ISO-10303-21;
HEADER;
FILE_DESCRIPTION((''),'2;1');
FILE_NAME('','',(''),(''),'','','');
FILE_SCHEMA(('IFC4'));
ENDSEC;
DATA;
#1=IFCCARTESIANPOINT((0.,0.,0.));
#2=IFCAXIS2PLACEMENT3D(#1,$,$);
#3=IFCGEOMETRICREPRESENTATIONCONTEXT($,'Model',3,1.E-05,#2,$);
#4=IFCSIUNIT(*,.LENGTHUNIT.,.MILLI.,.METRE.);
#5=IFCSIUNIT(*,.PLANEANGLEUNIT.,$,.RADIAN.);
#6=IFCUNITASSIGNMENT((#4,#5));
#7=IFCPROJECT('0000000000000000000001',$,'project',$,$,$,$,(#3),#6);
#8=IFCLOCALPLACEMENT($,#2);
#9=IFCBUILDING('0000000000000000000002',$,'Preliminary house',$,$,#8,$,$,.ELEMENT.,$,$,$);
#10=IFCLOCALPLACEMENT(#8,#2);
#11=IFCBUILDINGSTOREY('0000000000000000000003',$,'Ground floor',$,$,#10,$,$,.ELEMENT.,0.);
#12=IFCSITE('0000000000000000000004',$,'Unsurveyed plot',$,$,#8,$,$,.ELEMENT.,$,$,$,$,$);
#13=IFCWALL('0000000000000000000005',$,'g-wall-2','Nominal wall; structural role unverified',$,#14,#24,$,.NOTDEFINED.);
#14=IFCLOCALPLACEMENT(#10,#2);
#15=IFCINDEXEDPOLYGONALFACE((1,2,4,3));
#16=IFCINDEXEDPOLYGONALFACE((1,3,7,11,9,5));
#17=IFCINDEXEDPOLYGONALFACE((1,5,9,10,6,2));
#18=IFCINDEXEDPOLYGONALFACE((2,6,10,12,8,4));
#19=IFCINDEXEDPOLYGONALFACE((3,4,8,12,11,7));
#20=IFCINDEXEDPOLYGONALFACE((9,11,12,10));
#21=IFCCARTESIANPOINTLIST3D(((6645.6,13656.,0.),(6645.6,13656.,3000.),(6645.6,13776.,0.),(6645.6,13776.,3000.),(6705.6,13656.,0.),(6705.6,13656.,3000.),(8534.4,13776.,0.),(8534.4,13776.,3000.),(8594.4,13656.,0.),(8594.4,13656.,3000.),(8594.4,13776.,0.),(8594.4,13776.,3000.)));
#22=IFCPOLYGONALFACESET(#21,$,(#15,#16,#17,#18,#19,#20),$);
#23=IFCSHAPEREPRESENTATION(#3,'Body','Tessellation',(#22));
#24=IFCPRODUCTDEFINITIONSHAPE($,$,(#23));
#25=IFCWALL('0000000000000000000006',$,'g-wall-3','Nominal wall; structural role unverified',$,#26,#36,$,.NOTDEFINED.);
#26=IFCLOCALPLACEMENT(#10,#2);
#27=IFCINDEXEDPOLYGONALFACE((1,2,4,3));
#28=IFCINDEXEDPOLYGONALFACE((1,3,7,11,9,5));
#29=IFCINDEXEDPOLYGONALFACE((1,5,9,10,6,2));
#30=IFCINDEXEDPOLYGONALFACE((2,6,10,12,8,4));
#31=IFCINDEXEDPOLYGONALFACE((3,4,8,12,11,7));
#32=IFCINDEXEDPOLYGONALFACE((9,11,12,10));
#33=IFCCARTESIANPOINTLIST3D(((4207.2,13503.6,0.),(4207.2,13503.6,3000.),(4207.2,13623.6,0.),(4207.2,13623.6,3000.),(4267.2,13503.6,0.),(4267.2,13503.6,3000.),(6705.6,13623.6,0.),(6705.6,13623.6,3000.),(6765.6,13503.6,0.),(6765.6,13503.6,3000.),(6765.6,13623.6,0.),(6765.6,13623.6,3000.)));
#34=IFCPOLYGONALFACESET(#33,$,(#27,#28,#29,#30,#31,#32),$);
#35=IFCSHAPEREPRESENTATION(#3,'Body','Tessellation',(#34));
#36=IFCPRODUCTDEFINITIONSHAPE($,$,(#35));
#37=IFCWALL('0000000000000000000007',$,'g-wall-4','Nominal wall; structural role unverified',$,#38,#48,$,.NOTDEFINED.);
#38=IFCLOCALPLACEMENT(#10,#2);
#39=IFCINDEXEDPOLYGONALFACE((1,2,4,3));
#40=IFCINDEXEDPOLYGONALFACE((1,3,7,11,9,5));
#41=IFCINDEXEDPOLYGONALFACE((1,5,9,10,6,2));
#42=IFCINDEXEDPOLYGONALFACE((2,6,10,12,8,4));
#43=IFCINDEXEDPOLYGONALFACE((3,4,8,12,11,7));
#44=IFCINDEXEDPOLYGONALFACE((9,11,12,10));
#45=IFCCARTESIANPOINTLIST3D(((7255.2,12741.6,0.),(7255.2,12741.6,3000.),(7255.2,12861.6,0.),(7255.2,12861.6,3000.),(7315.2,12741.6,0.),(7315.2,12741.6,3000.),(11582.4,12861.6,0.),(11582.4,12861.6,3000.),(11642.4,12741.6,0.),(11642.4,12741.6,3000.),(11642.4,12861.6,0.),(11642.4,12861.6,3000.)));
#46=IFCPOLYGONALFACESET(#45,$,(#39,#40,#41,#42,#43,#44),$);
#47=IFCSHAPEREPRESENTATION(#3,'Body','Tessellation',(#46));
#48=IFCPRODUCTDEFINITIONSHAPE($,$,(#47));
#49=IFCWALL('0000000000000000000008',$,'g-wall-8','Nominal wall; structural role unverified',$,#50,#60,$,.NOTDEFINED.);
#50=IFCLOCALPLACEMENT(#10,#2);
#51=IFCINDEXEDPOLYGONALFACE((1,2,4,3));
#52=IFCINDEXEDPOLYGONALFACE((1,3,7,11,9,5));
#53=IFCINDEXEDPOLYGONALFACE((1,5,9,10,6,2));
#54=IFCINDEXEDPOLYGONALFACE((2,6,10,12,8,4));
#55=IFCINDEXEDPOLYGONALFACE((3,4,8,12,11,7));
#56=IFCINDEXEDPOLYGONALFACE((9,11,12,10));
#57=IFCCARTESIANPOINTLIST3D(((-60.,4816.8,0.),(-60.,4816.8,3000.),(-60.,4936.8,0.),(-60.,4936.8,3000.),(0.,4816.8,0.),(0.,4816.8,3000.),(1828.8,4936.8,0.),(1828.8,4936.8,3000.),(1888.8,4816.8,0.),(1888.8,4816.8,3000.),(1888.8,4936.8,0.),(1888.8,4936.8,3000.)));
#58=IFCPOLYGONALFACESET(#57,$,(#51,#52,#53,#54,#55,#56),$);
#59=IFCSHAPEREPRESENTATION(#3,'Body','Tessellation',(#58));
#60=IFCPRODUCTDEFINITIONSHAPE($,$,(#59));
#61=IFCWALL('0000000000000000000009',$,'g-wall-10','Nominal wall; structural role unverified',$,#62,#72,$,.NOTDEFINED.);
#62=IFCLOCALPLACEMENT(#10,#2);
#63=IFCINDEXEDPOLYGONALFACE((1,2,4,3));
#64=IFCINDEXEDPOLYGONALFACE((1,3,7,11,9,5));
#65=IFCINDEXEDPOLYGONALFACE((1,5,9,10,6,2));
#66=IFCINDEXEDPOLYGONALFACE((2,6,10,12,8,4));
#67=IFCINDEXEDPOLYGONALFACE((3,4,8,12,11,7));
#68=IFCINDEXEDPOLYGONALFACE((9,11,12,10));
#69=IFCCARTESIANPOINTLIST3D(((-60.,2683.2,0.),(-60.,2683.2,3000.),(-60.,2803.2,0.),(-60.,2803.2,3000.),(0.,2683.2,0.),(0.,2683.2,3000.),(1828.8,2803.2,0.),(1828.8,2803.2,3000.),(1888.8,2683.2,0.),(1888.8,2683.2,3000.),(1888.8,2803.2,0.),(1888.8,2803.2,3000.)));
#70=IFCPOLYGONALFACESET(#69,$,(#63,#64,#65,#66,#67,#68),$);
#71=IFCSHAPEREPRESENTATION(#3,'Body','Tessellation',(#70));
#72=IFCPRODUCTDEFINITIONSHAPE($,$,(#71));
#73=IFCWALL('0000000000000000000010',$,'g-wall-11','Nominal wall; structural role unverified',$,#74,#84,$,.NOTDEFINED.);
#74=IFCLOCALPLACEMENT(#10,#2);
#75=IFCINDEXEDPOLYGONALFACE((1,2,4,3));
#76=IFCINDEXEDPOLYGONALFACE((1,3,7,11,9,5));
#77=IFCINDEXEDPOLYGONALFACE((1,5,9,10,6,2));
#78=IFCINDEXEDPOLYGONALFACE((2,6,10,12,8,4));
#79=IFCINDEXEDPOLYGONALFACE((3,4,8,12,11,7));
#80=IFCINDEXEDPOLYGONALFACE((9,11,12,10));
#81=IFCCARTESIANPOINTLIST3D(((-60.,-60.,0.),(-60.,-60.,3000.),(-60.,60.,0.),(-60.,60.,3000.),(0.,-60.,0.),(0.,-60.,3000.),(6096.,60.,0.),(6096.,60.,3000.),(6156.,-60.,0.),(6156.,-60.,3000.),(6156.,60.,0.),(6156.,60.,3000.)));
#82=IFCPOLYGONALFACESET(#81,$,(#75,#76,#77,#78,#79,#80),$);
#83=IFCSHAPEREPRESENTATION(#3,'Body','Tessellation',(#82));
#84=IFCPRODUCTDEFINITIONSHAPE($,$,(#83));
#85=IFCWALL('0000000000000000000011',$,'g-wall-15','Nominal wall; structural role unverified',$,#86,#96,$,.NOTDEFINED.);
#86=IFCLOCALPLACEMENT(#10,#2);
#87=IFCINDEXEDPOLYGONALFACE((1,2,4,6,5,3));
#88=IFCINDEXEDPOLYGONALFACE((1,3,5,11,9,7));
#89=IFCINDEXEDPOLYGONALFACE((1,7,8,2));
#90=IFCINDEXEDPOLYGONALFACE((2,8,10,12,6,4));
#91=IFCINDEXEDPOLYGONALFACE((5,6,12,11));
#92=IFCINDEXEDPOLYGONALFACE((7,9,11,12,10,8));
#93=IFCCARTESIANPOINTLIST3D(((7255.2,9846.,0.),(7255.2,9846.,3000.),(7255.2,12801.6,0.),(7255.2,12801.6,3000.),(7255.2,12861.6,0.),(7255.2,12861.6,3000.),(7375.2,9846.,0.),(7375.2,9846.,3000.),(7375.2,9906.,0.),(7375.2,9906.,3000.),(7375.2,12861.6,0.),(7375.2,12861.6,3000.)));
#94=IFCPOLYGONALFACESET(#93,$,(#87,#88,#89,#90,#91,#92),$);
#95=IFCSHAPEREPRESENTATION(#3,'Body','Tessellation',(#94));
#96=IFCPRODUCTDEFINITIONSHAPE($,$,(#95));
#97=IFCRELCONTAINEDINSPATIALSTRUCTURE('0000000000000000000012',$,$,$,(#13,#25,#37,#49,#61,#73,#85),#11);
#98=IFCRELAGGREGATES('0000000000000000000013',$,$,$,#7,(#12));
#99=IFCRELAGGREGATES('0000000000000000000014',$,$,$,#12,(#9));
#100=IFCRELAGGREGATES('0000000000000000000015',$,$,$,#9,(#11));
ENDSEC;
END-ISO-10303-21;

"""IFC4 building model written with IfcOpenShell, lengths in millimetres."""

from ifc_helpers import new_model, si_unit, origin, place, context, project, spatial, polyline, outline, extrude, element, save


model = new_model("IFC4")

# Units and contexts
model_context = context("Model", 3, precision=1e-05, world=origin())
ifc_project = project(units=[si_unit("LENGTHUNIT", "METRE", prefix="MILLI"), si_unit("PLANEANGLEUNIT", "RADIAN")], contexts=[model_context])

# Site, building, storey
placement_1 = place(None, origin())
site = spatial("IfcSite", under=ifc_project, at=placement_1, Name="Unsurveyed plot", CompositionType="ELEMENT")
building = spatial("IfcBuilding", under=site, at=placement_1, Name="Preliminary house", CompositionType="ELEMENT")
placement_2 = place(placement_1, origin())
storey = spatial("IfcBuildingStorey", under=building, at=placement_2, Name="Ground floor", CompositionType="ELEMENT", Elevation=0.0)

# Walls
element("IfcWall", 1, at=placement_2, inside=storey, Name="g-wall-2", Description="Nominal wall; structural role unverified", PredefinedType="NOTDEFINED", context=model_context, shape_type="SweptSolid", body=[
    extrude(outline(polyline([(8534.4, 13776.0), (8594.4, 13776.0), (8594.4, 13656.0), (6705.6, 13656.0), (6645.6, 13656.0), (6645.6, 13776.0), (8534.4, 13776.0)])), origin(), (0.0, 0.0, 1.0), 3000.0),
])
element("IfcWall", 2, at=placement_2, inside=storey, Name="g-wall-3", Description="Nominal wall; structural role unverified", PredefinedType="NOTDEFINED", context=model_context, shape_type="SweptSolid", body=[
    extrude(outline(polyline([(6705.6, 13623.6), (6765.6, 13623.6), (6765.6, 13503.6), (4267.2, 13503.6), (4207.2, 13503.6), (4207.2, 13623.6), (6705.6, 13623.6)])), origin(), (0.0, 0.0, 1.0), 3000.0),
])
element("IfcWall", 3, at=placement_2, inside=storey, Name="g-wall-4", Description="Nominal wall; structural role unverified", PredefinedType="NOTDEFINED", context=model_context, shape_type="SweptSolid", body=[
    extrude(outline(polyline([(11582.4, 12861.6), (11642.4, 12861.6), (11642.4, 12741.6), (7315.2, 12741.6), (7255.2, 12741.6), (7255.2, 12861.6), (11582.4, 12861.6)])), origin(), (0.0, 0.0, 1.0), 3000.0),
])

# Wall
element("IfcWall", 4, at=placement_2, inside=storey, Name="g-wall-8", Description="Nominal wall; structural role unverified", PredefinedType="NOTDEFINED", context=model_context, shape_type="SweptSolid", body=[
    extrude(outline(polyline([(1828.8, 4936.8), (1888.8, 4936.8), (1888.8, 4816.8), (0.0, 4816.8), (-60.0, 4816.8), (-60.0, 4936.8), (1828.8, 4936.8)])), origin(), (0.0, 0.0, 1.0), 3000.0),
])

# Walls
element("IfcWall", 5, at=placement_2, inside=storey, Name="g-wall-10", Description="Nominal wall; structural role unverified", PredefinedType="NOTDEFINED", context=model_context, shape_type="SweptSolid", body=[
    extrude(outline(polyline([(1828.8, 2803.2), (1888.8, 2803.2), (1888.8, 2683.2), (0.0, 2683.2), (-60.0, 2683.2), (-60.0, 2803.2), (1828.8, 2803.2)])), origin(), (0.0, 0.0, 1.0), 3000.0),
])
element("IfcWall", 6, at=placement_2, inside=storey, Name="g-wall-11", Description="Nominal wall; structural role unverified", PredefinedType="NOTDEFINED", context=model_context, shape_type="SweptSolid", body=[
    extrude(outline(polyline([(6096.0, 60.0), (6156.0, 60.0), (6156.0, -60.0), (0.0, -60.0), (-60.0, -60.0), (-60.0, 60.0), (6096.0, 60.0)])), origin(), (0.0, 0.0, 1.0), 3000.0),
])

# Wall
element("IfcWall", 7, at=placement_2, inside=storey, Name="g-wall-15", Description="Nominal wall; structural role unverified", PredefinedType="NOTDEFINED", context=model_context, shape_type="SweptSolid", body=[
    extrude(outline(polyline([(7255.2, 12801.6), (7255.2, 12861.6), (7375.2, 12861.6), (7375.2, 9906.0), (7375.2, 9846.0), (7255.2, 9846.0), (7255.2, 12801.6)])), origin(), (0.0, 0.0, 1.0), 3000.0),
])

save(model, "model.ifc")
